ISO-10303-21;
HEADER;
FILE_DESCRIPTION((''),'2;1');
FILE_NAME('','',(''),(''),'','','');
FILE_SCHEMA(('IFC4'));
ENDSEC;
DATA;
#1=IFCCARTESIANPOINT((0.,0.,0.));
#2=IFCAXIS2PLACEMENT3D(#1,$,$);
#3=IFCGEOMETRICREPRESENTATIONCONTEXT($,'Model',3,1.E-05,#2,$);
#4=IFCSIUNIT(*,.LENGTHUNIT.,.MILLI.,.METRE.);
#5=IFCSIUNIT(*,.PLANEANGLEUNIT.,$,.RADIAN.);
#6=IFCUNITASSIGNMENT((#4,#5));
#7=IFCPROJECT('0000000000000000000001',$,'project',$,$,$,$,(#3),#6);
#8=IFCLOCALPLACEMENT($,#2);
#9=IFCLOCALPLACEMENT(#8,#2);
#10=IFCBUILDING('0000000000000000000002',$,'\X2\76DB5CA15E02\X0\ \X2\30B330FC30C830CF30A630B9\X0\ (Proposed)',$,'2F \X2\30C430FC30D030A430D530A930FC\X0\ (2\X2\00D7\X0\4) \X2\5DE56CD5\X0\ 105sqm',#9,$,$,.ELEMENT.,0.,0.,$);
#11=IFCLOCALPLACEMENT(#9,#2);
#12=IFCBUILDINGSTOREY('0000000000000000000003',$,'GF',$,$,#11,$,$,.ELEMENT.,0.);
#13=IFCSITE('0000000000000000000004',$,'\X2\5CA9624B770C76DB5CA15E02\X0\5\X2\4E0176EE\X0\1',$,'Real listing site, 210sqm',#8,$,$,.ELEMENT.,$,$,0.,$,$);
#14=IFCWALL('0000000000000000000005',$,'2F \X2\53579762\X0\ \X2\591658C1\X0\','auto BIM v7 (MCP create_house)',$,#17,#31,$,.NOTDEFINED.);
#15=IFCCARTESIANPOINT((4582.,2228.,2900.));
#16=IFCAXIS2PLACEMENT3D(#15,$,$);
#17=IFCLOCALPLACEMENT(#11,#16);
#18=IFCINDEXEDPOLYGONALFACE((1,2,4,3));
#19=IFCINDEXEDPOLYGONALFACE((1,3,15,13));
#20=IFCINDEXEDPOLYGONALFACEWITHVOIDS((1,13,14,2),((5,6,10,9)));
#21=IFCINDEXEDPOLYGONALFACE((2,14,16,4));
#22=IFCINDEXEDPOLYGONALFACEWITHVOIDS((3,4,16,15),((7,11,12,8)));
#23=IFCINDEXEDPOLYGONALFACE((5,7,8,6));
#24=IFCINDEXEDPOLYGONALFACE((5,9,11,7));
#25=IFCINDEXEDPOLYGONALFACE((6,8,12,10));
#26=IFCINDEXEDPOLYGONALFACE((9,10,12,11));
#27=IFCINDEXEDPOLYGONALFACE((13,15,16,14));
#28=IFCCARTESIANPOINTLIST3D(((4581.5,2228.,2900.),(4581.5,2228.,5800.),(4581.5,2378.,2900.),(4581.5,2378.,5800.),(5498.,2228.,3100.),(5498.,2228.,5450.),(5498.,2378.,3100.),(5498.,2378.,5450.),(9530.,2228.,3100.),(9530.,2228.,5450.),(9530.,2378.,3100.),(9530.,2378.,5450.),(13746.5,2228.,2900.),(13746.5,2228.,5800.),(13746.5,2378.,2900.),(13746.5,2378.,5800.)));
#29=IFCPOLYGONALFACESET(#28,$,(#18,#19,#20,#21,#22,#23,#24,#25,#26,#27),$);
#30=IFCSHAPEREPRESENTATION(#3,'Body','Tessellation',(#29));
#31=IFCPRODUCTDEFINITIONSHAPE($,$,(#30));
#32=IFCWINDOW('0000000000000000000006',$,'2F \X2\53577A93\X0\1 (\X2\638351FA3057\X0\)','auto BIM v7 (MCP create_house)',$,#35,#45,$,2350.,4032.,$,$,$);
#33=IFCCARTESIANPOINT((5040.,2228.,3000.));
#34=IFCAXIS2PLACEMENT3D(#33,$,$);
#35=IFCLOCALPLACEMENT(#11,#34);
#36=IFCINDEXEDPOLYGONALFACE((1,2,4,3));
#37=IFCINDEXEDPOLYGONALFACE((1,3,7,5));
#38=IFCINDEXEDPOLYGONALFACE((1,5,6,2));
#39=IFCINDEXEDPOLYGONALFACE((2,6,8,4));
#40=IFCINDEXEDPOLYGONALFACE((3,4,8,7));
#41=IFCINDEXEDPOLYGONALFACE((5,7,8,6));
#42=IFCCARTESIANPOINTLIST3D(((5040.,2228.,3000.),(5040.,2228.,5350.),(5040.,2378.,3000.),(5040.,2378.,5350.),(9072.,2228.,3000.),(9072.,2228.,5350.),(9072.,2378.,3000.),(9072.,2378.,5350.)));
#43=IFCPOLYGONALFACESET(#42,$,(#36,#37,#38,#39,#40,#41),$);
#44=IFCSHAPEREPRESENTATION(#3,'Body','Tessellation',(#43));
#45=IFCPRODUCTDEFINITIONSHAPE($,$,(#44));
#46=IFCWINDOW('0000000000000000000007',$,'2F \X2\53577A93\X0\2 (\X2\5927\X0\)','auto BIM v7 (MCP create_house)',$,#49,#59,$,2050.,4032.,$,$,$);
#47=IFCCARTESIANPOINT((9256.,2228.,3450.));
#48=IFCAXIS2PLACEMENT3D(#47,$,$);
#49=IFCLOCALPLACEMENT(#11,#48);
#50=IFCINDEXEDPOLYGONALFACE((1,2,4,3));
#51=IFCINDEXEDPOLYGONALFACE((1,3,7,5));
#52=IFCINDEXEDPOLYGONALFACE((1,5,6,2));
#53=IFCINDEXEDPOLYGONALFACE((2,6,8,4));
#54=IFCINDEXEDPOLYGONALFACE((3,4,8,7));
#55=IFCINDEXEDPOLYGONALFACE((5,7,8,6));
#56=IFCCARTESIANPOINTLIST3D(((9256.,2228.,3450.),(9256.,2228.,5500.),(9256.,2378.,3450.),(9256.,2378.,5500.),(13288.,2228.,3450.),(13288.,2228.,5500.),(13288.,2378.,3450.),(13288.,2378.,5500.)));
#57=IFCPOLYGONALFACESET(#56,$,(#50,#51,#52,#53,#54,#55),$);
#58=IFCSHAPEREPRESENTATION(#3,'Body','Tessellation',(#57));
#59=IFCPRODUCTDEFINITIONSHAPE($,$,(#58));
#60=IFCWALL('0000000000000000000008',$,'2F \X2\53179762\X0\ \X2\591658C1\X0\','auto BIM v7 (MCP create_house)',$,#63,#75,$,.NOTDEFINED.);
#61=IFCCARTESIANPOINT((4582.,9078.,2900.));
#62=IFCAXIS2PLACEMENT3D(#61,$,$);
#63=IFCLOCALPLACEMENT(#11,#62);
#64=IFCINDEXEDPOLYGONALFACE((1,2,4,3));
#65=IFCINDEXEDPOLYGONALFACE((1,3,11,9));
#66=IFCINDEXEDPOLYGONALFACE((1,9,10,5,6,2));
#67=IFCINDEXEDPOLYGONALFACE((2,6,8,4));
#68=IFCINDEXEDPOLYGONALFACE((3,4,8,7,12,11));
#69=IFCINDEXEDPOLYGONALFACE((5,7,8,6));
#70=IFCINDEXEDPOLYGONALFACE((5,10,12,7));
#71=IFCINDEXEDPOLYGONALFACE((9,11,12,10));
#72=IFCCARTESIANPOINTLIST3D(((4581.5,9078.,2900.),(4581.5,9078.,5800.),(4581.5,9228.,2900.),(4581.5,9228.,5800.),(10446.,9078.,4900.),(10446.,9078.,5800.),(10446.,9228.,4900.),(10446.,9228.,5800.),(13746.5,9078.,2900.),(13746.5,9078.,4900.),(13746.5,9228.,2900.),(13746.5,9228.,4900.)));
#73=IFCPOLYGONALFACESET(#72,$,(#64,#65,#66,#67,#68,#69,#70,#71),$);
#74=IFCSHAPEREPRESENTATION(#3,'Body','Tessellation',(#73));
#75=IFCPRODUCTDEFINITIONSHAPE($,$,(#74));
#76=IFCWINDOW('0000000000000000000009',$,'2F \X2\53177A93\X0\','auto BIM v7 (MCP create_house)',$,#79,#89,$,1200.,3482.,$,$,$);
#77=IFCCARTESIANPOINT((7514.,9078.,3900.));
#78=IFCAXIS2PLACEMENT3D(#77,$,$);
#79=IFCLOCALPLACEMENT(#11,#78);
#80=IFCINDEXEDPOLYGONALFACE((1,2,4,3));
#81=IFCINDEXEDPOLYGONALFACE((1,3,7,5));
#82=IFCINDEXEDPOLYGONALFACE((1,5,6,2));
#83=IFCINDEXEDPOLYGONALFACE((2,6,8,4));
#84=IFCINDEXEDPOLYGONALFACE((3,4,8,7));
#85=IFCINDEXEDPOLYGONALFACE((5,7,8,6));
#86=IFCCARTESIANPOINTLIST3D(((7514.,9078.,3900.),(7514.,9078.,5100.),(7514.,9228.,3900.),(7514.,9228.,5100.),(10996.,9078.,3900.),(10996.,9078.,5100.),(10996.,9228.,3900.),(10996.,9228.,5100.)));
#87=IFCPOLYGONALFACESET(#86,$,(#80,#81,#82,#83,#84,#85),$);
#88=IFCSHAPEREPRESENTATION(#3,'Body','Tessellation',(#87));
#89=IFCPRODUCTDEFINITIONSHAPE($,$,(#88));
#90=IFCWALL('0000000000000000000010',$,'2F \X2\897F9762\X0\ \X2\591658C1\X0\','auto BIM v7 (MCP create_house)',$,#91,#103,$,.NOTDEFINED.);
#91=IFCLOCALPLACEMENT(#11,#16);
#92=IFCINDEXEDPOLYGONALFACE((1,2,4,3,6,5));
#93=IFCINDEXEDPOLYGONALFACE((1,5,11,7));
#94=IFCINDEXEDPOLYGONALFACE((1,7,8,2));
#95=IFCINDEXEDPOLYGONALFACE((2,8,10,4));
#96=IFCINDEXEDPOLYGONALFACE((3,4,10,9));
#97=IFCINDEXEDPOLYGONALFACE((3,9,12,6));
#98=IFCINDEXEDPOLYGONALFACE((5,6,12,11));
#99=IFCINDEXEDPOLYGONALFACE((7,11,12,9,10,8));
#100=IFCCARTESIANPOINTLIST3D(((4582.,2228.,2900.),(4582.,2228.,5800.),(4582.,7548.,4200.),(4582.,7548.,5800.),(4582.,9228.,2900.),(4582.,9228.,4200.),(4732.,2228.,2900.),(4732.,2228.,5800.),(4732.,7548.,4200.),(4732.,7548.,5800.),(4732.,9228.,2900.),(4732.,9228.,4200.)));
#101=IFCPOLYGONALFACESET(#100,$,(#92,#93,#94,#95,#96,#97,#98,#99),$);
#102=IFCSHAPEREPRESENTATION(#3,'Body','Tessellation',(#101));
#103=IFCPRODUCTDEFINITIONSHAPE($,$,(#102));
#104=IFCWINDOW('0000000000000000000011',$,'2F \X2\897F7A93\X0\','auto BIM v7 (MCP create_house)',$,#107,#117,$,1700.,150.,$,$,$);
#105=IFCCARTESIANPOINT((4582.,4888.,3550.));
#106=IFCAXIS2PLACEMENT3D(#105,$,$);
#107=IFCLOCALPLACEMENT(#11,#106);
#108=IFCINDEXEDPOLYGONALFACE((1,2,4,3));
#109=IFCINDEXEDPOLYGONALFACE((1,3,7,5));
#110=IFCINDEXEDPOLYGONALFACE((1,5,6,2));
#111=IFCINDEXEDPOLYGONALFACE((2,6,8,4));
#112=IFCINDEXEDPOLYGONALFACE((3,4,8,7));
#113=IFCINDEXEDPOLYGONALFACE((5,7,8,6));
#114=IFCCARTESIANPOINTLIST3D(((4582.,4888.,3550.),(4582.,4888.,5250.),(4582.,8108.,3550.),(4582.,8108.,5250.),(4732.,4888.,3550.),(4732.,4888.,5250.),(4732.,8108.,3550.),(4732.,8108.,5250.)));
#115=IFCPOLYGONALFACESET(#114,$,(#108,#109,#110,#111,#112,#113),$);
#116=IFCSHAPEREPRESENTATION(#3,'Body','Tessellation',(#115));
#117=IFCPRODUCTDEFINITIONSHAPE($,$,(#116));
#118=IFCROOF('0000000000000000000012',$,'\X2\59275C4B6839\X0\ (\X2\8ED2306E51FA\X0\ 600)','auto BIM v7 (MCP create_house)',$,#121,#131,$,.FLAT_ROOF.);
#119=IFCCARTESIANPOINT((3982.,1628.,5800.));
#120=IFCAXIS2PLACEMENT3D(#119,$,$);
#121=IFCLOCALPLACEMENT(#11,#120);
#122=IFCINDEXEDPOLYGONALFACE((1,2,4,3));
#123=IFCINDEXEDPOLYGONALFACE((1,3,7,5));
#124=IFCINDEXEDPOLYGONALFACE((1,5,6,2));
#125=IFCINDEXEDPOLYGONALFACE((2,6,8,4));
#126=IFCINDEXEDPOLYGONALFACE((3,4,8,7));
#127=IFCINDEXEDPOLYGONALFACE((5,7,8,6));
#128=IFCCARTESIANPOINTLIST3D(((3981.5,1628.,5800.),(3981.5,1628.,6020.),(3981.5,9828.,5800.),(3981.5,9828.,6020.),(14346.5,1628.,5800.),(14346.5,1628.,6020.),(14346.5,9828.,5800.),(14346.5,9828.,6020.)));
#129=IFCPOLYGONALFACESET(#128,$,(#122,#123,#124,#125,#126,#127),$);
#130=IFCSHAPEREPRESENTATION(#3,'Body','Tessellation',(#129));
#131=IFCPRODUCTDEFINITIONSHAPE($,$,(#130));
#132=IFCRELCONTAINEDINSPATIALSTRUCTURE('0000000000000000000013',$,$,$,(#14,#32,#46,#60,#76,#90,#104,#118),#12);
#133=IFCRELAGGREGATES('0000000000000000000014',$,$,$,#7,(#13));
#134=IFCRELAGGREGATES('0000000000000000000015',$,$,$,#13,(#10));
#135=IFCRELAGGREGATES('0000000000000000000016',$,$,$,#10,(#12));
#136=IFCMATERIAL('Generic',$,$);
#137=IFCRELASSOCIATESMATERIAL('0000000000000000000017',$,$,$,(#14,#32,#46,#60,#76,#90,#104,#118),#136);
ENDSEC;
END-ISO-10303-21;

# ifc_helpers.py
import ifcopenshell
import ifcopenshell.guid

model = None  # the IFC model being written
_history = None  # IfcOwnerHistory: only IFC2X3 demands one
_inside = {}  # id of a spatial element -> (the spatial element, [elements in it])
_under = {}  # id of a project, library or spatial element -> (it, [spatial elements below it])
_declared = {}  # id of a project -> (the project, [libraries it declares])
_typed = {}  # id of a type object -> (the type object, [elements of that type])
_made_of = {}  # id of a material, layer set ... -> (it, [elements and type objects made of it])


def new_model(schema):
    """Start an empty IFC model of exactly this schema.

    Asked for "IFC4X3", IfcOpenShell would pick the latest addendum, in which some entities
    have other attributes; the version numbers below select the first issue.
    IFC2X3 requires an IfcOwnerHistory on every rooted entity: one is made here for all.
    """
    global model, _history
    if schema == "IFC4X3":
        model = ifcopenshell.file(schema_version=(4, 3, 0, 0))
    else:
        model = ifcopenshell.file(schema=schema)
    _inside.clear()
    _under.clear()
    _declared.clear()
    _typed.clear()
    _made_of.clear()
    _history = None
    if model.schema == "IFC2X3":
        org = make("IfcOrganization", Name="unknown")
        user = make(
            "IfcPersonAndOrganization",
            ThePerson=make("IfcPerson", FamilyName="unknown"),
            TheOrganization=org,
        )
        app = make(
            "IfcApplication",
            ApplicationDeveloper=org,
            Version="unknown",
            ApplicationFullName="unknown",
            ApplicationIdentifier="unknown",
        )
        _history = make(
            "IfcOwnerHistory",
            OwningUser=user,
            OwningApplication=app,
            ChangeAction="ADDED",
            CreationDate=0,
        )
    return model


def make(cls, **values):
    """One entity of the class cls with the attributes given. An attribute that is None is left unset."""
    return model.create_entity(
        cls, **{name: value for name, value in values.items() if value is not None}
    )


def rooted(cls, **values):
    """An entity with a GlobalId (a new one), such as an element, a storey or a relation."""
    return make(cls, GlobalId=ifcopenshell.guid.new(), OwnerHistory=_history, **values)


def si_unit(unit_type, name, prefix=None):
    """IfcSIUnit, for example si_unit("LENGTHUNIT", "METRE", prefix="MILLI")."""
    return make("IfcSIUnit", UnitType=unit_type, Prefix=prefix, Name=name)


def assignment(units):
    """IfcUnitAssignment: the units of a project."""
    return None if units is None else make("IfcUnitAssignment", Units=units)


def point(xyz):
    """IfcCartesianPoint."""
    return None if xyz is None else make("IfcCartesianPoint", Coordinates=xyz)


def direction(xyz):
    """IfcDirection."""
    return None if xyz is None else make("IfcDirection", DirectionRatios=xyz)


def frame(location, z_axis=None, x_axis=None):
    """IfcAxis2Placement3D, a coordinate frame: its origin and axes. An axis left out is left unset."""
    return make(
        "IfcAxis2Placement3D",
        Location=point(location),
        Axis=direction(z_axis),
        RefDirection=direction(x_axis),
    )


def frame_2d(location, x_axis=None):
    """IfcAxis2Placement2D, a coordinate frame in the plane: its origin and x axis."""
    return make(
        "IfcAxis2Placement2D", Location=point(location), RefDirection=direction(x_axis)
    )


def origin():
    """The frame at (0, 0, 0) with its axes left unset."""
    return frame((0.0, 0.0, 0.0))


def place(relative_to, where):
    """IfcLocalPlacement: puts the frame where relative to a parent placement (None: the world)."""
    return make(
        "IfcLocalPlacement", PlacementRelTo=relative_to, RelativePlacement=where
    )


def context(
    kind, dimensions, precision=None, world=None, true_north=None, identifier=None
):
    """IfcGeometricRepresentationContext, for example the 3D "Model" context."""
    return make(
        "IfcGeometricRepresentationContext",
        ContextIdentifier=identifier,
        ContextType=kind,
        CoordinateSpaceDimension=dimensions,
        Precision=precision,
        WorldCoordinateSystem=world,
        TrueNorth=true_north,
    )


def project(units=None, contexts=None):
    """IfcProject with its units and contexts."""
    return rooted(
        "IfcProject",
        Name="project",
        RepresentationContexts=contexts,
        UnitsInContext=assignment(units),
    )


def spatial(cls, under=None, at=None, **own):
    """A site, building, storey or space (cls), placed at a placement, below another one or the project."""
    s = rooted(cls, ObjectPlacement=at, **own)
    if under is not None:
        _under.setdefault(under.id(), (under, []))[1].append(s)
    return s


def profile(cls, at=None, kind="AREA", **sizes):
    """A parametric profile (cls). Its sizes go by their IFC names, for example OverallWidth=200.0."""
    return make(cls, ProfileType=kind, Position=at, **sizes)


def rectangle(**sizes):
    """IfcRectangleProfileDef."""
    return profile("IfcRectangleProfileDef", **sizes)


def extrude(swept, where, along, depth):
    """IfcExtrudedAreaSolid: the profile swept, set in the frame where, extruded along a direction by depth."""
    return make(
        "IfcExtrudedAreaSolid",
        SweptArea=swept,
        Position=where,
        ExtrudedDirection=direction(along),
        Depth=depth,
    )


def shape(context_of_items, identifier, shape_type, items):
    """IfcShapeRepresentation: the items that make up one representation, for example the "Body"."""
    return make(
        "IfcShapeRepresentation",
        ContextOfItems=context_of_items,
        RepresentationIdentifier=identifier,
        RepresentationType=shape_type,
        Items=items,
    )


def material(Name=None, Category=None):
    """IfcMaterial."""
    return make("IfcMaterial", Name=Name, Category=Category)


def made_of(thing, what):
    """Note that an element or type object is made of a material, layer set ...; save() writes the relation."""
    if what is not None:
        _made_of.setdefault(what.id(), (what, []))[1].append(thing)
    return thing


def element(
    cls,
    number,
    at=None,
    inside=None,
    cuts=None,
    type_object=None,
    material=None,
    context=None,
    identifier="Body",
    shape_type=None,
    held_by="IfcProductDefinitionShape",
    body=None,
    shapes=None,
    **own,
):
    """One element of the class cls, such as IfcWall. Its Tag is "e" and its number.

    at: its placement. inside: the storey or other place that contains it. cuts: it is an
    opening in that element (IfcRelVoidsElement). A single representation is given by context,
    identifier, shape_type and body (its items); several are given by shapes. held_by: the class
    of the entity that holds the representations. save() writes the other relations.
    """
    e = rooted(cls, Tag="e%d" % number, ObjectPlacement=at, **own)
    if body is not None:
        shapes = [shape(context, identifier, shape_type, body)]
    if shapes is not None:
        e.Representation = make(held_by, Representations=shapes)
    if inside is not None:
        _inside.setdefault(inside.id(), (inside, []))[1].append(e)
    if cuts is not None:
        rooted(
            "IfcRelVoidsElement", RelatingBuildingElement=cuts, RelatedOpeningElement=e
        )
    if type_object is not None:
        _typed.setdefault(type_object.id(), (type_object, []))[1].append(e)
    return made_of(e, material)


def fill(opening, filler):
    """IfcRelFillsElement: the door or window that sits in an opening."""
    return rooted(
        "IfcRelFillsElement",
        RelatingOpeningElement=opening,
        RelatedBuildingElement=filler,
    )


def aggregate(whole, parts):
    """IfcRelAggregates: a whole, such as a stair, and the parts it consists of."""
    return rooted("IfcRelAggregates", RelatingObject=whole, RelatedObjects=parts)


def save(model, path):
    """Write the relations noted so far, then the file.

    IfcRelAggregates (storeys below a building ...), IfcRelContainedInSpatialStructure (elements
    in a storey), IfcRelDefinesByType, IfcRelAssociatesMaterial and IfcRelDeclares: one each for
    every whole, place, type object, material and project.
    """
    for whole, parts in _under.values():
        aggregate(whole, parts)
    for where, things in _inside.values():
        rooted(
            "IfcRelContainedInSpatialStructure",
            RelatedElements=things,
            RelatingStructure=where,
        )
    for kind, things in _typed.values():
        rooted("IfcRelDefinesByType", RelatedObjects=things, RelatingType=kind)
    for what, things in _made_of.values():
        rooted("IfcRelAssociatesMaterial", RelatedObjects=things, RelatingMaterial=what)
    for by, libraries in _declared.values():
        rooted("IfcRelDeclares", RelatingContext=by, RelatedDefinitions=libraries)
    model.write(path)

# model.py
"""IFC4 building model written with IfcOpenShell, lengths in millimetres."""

from ifc_helpers import new_model, si_unit, frame, frame_2d, origin, place, context, project, spatial, rectangle, extrude, material, element, fill, save


model = new_model("IFC4")

# Units and contexts
model_context = context("Model", 3, precision=1e-05, world=origin())
ifc_project = project(units=[si_unit("LENGTHUNIT", "METRE", prefix="MILLI"), si_unit("PLANEANGLEUNIT", "RADIAN")], contexts=[model_context])

# Site, building, storey
site_placement = place(None, origin())
site = spatial("IfcSite", under=ifc_project, at=site_placement, Name="岩手県盛岡市5丁目1", ObjectType="Real listing site, 210sqm", CompositionType="ELEMENT", RefElevation=0.0)
building_placement = place(site_placement, origin())
building = spatial("IfcBuilding", under=site, at=building_placement, Name="盛岡市 コートハウス (Proposed)", ObjectType="2F ツーバイフォー (2×4) 工法 105sqm", CompositionType="ELEMENT", ElevationOfRefHeight=0.0, ElevationOfTerrain=0.0)
storey_placement = place(building_placement, origin())
storey = spatial("IfcBuildingStorey", under=building, at=storey_placement, Name="GF", CompositionType="ELEMENT", Elevation=0.0)

# Shared definitions
ifc_material = material(Name="Generic")

# Wall, openings, windows
wall_1_placement = place(storey_placement, frame((4582.0, 2228.0, 2900.0)))
wall_1 = element("IfcWall", 1, at=wall_1_placement, inside=storey, material=ifc_material, Name="2F 南面 外壁", Description="auto BIM v7 (MCP create_house)", PredefinedType="NOTDEFINED", context=model_context, shape_type="SweptSolid", body=[
    extrude(rectangle(XDim=9165.0, YDim=150.0, at=frame_2d((4582.0, 75.0))), frame((4582.0, 2228.0, 2900.0)), (0.0, 0.0, 1.0), 2900.0),
])
opening_1_placement = place(storey_placement, frame((5040.0, 2228.0, 3000.0)))
opening_1 = element("IfcOpeningElement", 2, at=opening_1_placement, cuts=wall_1, PredefinedType="NOTDEFINED", context=model_context, shape_type="SweptSolid", body=[
    extrude(rectangle(XDim=4032.0, YDim=150.0, at=frame_2d((2016.0, 75.0))), frame((5040.0, 2228.0, 3000.0)), (0.0, 0.0, 1.0), 2350.0),
])
opening_2_placement = place(storey_placement, frame((9256.0, 2228.0, 3450.0)))
opening_2 = element("IfcOpeningElement", 3, at=opening_2_placement, cuts=wall_1, PredefinedType="NOTDEFINED", context=model_context, shape_type="SweptSolid", body=[
    extrude(rectangle(XDim=4032.0, YDim=150.0, at=frame_2d((2016.0, 75.0))), frame((9256.0, 2228.0, 3450.0)), (0.0, 0.0, 1.0), 2050.0),
])
window_1_placement = place(storey_placement, frame((5040.0, 2228.0, 3000.0)))
window_1 = element("IfcWindow", 4, at=window_1_placement, inside=storey, material=ifc_material, Name="2F 南窓1 (掃出し)", Description="auto BIM v7 (MCP create_house)", OverallHeight=2350.0, OverallWidth=4032.0, context=model_context, shape_type="SweptSolid", body=[
    extrude(rectangle(XDim=4032.0, YDim=150.0, at=frame_2d((2016.0, 75.0))), frame((5040.0, 2228.0, 3000.0)), (0.0, 0.0, 1.0), 2350.0),
])
fill(opening_1, window_1)
window_2_placement = place(storey_placement, frame((9256.0, 2228.0, 3450.0)))
window_2 = element("IfcWindow", 5, at=window_2_placement, inside=storey, material=ifc_material, Name="2F 南窓2 (大)", Description="auto BIM v7 (MCP create_house)", OverallHeight=2050.0, OverallWidth=4032.0, context=model_context, shape_type="SweptSolid", body=[
    extrude(rectangle(XDim=4032.0, YDim=150.0, at=frame_2d((2016.0, 75.0))), frame((9256.0, 2228.0, 3450.0)), (0.0, 0.0, 1.0), 2050.0),
])
fill(opening_2, window_2)

# Walls, openings, windows
wall_2_placement = place(storey_placement, frame((4582.0, 9078.0, 2900.0)))
wall_2 = element("IfcWall", 6, at=wall_2_placement, inside=storey, material=ifc_material, Name="2F 北面 外壁", Description="auto BIM v7 (MCP create_house)", PredefinedType="NOTDEFINED", context=model_context, shape_type="SweptSolid", body=[
    extrude(rectangle(XDim=9165.0, YDim=150.0, at=frame_2d((4582.0, 75.0))), frame((4582.0, 9078.0, 2900.0)), (0.0, 0.0, 1.0), 2900.0),
])
opening_3_placement = place(storey_placement, frame((7514.0, 9078.0, 3900.0)))
opening_3 = element("IfcOpeningElement", 7, at=opening_3_placement, cuts=wall_2, PredefinedType="NOTDEFINED", context=model_context, shape_type="SweptSolid", body=[
    extrude(rectangle(XDim=3482.0, YDim=150.0, at=frame_2d((1741.0, 75.0))), frame((7514.0, 9078.0, 3900.0)), (0.0, 0.0, 1.0), 1200.0),
])
window_3_placement = place(storey_placement, frame((7514.0, 9078.0, 3900.0)))
window_3 = element("IfcWindow", 8, at=window_3_placement, inside=storey, material=ifc_material, Name="2F 北窓", Description="auto BIM v7 (MCP create_house)", OverallHeight=1200.0, OverallWidth=3482.0, context=model_context, shape_type="SweptSolid", body=[
    extrude(rectangle(XDim=3482.0, YDim=150.0, at=frame_2d((1741.0, 75.0))), frame((7514.0, 9078.0, 3900.0)), (0.0, 0.0, 1.0), 1200.0),
])
fill(opening_3, window_3)
wall_3_placement = place(storey_placement, frame((4582.0, 2228.0, 2900.0)))
wall_3 = element("IfcWall", 9, at=wall_3_placement, inside=storey, material=ifc_material, Name="2F 西面 外壁", Description="auto BIM v7 (MCP create_house)", PredefinedType="NOTDEFINED", context=model_context, shape_type="SweptSolid", body=[
    extrude(rectangle(XDim=150.0, YDim=7000.0, at=frame_2d((75.0, 3500.0))), frame((4582.0, 2228.0, 2900.0)), (0.0, 0.0, 1.0), 2900.0),
])
opening_4_placement = place(storey_placement, frame((4582.0, 4888.0, 3550.0)))
opening_4 = element("IfcOpeningElement", 10, at=opening_4_placement, cuts=wall_3, PredefinedType="NOTDEFINED", context=model_context, shape_type="SweptSolid", body=[
    extrude(rectangle(XDim=150.0, YDim=3220.0, at=frame_2d((75.0, 1610.0))), frame((4582.0, 4888.0, 3550.0)), (0.0, 0.0, 1.0), 1700.0),
])
window_4_placement = place(storey_placement, frame((4582.0, 4888.0, 3550.0)))
window_4 = element("IfcWindow", 11, at=window_4_placement, inside=storey, material=ifc_material, Name="2F 西窓", Description="auto BIM v7 (MCP create_house)", OverallHeight=1700.0, OverallWidth=150.0, context=model_context, shape_type="SweptSolid", body=[
    extrude(rectangle(XDim=150.0, YDim=3220.0, at=frame_2d((75.0, 1610.0))), frame((4582.0, 4888.0, 3550.0)), (0.0, 0.0, 1.0), 1700.0),
])
fill(opening_4, window_4)

# Roof
roof_placement = place(storey_placement, frame((3982.0, 1628.0, 5800.0)))
element("IfcRoof", 12, at=roof_placement, inside=storey, material=ifc_material, Name="大屋根 (軒の出 600)", Description="auto BIM v7 (MCP create_house)", PredefinedType="FLAT_ROOF", context=model_context, shape_type="SweptSolid", body=[
    extrude(rectangle(XDim=10365.0, YDim=8200.0, at=frame_2d((5182.0, 4100.0))), frame((3982.0, 1628.0, 5800.0)), (0.0, 0.0, 1.0), 220.0),
])

save(model, "model.ifc")
